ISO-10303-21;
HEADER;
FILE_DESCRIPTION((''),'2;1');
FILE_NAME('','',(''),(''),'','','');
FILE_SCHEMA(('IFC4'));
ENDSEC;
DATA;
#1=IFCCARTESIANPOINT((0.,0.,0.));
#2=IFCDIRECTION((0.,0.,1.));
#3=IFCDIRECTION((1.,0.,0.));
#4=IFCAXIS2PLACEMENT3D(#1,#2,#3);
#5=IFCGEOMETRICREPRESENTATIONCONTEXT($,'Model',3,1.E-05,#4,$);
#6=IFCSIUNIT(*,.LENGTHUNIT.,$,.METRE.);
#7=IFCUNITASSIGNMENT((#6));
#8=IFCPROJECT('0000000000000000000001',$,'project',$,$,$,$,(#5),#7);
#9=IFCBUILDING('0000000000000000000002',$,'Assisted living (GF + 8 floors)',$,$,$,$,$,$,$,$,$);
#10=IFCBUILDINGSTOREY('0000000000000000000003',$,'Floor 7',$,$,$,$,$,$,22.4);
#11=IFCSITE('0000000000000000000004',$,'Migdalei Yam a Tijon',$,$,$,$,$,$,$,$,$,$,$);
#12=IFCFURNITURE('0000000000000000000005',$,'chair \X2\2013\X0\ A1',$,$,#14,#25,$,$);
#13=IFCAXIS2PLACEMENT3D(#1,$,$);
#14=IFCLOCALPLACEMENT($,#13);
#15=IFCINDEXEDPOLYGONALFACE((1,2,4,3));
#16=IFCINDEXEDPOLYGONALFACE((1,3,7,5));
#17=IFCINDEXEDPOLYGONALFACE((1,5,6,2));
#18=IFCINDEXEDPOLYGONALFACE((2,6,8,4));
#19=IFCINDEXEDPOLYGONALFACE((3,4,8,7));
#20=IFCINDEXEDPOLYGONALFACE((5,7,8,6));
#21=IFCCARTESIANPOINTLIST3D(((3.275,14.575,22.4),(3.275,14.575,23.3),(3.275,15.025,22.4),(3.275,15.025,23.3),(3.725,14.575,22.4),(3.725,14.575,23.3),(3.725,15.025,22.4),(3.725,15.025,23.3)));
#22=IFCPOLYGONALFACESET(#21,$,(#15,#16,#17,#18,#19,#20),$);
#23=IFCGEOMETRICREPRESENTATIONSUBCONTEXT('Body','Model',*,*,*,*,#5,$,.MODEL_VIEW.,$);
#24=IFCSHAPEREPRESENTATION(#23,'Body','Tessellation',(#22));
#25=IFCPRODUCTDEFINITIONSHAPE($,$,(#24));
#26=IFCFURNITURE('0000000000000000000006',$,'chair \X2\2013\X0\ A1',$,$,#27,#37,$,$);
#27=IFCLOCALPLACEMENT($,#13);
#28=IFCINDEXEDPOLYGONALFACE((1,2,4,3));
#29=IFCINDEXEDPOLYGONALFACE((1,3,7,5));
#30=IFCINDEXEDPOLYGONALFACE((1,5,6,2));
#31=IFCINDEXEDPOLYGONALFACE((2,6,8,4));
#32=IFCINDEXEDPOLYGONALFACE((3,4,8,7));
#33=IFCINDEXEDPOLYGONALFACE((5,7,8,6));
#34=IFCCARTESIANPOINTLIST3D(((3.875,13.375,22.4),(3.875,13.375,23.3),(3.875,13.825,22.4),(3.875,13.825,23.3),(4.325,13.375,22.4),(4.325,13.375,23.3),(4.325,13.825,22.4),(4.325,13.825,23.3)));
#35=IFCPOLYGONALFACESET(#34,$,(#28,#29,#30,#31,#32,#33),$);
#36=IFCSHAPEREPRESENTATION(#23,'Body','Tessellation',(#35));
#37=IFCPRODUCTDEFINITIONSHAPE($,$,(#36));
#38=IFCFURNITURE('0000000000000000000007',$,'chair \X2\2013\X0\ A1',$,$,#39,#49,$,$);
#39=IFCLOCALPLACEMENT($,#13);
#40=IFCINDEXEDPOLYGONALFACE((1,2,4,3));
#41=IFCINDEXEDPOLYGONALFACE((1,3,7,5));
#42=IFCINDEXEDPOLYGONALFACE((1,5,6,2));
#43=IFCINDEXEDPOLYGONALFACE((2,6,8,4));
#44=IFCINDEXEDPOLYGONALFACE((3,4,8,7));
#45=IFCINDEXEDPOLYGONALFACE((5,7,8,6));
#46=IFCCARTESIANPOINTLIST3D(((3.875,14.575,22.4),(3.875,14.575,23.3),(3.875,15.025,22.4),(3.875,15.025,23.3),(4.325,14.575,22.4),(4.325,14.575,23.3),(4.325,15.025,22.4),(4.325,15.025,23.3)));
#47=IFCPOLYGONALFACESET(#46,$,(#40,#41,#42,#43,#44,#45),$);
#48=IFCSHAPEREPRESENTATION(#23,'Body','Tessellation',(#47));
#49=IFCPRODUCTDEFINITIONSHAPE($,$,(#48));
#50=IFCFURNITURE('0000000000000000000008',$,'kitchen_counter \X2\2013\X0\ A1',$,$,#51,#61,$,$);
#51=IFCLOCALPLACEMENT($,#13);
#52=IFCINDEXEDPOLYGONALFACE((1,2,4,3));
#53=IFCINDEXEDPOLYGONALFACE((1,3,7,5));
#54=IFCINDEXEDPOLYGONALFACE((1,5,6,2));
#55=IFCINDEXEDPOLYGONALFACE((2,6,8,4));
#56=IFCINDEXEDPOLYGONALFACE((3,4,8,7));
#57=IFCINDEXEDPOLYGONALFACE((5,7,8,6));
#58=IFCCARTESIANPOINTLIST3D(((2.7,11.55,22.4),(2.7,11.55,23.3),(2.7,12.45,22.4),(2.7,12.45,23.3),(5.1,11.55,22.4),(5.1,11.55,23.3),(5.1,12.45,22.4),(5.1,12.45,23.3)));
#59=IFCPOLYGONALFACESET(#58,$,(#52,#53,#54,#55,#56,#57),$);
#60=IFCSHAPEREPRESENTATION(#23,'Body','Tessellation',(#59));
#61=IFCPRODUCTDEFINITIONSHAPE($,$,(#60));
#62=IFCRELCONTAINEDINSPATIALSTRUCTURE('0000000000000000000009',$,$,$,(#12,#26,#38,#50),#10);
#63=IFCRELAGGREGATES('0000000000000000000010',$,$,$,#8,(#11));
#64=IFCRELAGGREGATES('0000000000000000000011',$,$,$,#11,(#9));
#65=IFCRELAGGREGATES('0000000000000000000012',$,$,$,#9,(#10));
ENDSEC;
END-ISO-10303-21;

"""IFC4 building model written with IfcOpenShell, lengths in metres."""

from ifc_helpers import new_model, si_unit, frame, origin_with_axes, context, subcontext, project, spatial, line, indexed_curve, outline, extrude, element, save


model = new_model("IFC4")

# Units and contexts
model_context = context("Model", 3, precision=1e-05, world=origin_with_axes())
body_context = subcontext(model_context, "Body", "Model", "MODEL_VIEW")
ifc_project = project(units=[si_unit("LENGTHUNIT", "METRE")], contexts=[model_context])

# Site, building, storey
site = spatial("IfcSite", under=ifc_project, Name="Migdalei Yam a Tijon")
building = spatial("IfcBuilding", under=site, Name="Assisted living (GF + 8 floors)")
storey = spatial("IfcBuildingStorey", under=building, Name="Floor 7", Elevation=22.4)

# Furniture
element("IfcFurniture", 1, inside=storey, Name="chair – A1", context=body_context, shape_type="SweptSolid", body=[
    extrude(outline(indexed_curve([(0.0, 0.0), (0.45, 0.0), (0.45, 0.45), (0.0, 0.45)], segments=[line(1, 2, 3, 4, 1)])), frame((3.275, 14.575, 22.4), z_axis=(0.0, 0.0, 1.0), x_axis=(1.0, 0.0, 0.0)), (0.0, 0.0, 1.0), 0.9),
])
element("IfcFurniture", 2, inside=storey, Name="chair – A1", context=body_context, shape_type="SweptSolid", body=[
    extrude(outline(indexed_curve([(0.0, 0.0), (0.45, 0.0), (0.45, 0.45), (0.0, 0.45)], segments=[line(1, 2, 3, 4, 1)])), frame((3.875, 13.375, 22.4), z_axis=(0.0, 0.0, 1.0), x_axis=(1.0, 0.0, 0.0)), (0.0, 0.0, 1.0), 0.9),
])
element("IfcFurniture", 3, inside=storey, Name="chair – A1", context=body_context, shape_type="SweptSolid", body=[
    extrude(outline(indexed_curve([(0.0, 0.0), (0.45, 0.0), (0.45, 0.45), (0.0, 0.45)], segments=[line(1, 2, 3, 4, 1)])), frame((3.875, 14.575, 22.4), z_axis=(0.0, 0.0, 1.0), x_axis=(1.0, 0.0, 0.0)), (0.0, 0.0, 1.0), 0.9),
])
element("IfcFurniture", 4, inside=storey, Name="kitchen_counter – A1", context=body_context, shape_type="SweptSolid", body=[
    extrude(outline(indexed_curve([(0.0, 0.0), (2.4, 0.0), (2.4, 0.9), (0.0, 0.9)], segments=[line(1, 2, 3, 4, 1)])), frame((2.7, 11.55, 22.4), z_axis=(0.0, 0.0, 1.0), x_axis=(1.0, 0.0, 0.0)), (0.0, 0.0, 1.0), 0.9),
])

save(model, "model.ifc")
